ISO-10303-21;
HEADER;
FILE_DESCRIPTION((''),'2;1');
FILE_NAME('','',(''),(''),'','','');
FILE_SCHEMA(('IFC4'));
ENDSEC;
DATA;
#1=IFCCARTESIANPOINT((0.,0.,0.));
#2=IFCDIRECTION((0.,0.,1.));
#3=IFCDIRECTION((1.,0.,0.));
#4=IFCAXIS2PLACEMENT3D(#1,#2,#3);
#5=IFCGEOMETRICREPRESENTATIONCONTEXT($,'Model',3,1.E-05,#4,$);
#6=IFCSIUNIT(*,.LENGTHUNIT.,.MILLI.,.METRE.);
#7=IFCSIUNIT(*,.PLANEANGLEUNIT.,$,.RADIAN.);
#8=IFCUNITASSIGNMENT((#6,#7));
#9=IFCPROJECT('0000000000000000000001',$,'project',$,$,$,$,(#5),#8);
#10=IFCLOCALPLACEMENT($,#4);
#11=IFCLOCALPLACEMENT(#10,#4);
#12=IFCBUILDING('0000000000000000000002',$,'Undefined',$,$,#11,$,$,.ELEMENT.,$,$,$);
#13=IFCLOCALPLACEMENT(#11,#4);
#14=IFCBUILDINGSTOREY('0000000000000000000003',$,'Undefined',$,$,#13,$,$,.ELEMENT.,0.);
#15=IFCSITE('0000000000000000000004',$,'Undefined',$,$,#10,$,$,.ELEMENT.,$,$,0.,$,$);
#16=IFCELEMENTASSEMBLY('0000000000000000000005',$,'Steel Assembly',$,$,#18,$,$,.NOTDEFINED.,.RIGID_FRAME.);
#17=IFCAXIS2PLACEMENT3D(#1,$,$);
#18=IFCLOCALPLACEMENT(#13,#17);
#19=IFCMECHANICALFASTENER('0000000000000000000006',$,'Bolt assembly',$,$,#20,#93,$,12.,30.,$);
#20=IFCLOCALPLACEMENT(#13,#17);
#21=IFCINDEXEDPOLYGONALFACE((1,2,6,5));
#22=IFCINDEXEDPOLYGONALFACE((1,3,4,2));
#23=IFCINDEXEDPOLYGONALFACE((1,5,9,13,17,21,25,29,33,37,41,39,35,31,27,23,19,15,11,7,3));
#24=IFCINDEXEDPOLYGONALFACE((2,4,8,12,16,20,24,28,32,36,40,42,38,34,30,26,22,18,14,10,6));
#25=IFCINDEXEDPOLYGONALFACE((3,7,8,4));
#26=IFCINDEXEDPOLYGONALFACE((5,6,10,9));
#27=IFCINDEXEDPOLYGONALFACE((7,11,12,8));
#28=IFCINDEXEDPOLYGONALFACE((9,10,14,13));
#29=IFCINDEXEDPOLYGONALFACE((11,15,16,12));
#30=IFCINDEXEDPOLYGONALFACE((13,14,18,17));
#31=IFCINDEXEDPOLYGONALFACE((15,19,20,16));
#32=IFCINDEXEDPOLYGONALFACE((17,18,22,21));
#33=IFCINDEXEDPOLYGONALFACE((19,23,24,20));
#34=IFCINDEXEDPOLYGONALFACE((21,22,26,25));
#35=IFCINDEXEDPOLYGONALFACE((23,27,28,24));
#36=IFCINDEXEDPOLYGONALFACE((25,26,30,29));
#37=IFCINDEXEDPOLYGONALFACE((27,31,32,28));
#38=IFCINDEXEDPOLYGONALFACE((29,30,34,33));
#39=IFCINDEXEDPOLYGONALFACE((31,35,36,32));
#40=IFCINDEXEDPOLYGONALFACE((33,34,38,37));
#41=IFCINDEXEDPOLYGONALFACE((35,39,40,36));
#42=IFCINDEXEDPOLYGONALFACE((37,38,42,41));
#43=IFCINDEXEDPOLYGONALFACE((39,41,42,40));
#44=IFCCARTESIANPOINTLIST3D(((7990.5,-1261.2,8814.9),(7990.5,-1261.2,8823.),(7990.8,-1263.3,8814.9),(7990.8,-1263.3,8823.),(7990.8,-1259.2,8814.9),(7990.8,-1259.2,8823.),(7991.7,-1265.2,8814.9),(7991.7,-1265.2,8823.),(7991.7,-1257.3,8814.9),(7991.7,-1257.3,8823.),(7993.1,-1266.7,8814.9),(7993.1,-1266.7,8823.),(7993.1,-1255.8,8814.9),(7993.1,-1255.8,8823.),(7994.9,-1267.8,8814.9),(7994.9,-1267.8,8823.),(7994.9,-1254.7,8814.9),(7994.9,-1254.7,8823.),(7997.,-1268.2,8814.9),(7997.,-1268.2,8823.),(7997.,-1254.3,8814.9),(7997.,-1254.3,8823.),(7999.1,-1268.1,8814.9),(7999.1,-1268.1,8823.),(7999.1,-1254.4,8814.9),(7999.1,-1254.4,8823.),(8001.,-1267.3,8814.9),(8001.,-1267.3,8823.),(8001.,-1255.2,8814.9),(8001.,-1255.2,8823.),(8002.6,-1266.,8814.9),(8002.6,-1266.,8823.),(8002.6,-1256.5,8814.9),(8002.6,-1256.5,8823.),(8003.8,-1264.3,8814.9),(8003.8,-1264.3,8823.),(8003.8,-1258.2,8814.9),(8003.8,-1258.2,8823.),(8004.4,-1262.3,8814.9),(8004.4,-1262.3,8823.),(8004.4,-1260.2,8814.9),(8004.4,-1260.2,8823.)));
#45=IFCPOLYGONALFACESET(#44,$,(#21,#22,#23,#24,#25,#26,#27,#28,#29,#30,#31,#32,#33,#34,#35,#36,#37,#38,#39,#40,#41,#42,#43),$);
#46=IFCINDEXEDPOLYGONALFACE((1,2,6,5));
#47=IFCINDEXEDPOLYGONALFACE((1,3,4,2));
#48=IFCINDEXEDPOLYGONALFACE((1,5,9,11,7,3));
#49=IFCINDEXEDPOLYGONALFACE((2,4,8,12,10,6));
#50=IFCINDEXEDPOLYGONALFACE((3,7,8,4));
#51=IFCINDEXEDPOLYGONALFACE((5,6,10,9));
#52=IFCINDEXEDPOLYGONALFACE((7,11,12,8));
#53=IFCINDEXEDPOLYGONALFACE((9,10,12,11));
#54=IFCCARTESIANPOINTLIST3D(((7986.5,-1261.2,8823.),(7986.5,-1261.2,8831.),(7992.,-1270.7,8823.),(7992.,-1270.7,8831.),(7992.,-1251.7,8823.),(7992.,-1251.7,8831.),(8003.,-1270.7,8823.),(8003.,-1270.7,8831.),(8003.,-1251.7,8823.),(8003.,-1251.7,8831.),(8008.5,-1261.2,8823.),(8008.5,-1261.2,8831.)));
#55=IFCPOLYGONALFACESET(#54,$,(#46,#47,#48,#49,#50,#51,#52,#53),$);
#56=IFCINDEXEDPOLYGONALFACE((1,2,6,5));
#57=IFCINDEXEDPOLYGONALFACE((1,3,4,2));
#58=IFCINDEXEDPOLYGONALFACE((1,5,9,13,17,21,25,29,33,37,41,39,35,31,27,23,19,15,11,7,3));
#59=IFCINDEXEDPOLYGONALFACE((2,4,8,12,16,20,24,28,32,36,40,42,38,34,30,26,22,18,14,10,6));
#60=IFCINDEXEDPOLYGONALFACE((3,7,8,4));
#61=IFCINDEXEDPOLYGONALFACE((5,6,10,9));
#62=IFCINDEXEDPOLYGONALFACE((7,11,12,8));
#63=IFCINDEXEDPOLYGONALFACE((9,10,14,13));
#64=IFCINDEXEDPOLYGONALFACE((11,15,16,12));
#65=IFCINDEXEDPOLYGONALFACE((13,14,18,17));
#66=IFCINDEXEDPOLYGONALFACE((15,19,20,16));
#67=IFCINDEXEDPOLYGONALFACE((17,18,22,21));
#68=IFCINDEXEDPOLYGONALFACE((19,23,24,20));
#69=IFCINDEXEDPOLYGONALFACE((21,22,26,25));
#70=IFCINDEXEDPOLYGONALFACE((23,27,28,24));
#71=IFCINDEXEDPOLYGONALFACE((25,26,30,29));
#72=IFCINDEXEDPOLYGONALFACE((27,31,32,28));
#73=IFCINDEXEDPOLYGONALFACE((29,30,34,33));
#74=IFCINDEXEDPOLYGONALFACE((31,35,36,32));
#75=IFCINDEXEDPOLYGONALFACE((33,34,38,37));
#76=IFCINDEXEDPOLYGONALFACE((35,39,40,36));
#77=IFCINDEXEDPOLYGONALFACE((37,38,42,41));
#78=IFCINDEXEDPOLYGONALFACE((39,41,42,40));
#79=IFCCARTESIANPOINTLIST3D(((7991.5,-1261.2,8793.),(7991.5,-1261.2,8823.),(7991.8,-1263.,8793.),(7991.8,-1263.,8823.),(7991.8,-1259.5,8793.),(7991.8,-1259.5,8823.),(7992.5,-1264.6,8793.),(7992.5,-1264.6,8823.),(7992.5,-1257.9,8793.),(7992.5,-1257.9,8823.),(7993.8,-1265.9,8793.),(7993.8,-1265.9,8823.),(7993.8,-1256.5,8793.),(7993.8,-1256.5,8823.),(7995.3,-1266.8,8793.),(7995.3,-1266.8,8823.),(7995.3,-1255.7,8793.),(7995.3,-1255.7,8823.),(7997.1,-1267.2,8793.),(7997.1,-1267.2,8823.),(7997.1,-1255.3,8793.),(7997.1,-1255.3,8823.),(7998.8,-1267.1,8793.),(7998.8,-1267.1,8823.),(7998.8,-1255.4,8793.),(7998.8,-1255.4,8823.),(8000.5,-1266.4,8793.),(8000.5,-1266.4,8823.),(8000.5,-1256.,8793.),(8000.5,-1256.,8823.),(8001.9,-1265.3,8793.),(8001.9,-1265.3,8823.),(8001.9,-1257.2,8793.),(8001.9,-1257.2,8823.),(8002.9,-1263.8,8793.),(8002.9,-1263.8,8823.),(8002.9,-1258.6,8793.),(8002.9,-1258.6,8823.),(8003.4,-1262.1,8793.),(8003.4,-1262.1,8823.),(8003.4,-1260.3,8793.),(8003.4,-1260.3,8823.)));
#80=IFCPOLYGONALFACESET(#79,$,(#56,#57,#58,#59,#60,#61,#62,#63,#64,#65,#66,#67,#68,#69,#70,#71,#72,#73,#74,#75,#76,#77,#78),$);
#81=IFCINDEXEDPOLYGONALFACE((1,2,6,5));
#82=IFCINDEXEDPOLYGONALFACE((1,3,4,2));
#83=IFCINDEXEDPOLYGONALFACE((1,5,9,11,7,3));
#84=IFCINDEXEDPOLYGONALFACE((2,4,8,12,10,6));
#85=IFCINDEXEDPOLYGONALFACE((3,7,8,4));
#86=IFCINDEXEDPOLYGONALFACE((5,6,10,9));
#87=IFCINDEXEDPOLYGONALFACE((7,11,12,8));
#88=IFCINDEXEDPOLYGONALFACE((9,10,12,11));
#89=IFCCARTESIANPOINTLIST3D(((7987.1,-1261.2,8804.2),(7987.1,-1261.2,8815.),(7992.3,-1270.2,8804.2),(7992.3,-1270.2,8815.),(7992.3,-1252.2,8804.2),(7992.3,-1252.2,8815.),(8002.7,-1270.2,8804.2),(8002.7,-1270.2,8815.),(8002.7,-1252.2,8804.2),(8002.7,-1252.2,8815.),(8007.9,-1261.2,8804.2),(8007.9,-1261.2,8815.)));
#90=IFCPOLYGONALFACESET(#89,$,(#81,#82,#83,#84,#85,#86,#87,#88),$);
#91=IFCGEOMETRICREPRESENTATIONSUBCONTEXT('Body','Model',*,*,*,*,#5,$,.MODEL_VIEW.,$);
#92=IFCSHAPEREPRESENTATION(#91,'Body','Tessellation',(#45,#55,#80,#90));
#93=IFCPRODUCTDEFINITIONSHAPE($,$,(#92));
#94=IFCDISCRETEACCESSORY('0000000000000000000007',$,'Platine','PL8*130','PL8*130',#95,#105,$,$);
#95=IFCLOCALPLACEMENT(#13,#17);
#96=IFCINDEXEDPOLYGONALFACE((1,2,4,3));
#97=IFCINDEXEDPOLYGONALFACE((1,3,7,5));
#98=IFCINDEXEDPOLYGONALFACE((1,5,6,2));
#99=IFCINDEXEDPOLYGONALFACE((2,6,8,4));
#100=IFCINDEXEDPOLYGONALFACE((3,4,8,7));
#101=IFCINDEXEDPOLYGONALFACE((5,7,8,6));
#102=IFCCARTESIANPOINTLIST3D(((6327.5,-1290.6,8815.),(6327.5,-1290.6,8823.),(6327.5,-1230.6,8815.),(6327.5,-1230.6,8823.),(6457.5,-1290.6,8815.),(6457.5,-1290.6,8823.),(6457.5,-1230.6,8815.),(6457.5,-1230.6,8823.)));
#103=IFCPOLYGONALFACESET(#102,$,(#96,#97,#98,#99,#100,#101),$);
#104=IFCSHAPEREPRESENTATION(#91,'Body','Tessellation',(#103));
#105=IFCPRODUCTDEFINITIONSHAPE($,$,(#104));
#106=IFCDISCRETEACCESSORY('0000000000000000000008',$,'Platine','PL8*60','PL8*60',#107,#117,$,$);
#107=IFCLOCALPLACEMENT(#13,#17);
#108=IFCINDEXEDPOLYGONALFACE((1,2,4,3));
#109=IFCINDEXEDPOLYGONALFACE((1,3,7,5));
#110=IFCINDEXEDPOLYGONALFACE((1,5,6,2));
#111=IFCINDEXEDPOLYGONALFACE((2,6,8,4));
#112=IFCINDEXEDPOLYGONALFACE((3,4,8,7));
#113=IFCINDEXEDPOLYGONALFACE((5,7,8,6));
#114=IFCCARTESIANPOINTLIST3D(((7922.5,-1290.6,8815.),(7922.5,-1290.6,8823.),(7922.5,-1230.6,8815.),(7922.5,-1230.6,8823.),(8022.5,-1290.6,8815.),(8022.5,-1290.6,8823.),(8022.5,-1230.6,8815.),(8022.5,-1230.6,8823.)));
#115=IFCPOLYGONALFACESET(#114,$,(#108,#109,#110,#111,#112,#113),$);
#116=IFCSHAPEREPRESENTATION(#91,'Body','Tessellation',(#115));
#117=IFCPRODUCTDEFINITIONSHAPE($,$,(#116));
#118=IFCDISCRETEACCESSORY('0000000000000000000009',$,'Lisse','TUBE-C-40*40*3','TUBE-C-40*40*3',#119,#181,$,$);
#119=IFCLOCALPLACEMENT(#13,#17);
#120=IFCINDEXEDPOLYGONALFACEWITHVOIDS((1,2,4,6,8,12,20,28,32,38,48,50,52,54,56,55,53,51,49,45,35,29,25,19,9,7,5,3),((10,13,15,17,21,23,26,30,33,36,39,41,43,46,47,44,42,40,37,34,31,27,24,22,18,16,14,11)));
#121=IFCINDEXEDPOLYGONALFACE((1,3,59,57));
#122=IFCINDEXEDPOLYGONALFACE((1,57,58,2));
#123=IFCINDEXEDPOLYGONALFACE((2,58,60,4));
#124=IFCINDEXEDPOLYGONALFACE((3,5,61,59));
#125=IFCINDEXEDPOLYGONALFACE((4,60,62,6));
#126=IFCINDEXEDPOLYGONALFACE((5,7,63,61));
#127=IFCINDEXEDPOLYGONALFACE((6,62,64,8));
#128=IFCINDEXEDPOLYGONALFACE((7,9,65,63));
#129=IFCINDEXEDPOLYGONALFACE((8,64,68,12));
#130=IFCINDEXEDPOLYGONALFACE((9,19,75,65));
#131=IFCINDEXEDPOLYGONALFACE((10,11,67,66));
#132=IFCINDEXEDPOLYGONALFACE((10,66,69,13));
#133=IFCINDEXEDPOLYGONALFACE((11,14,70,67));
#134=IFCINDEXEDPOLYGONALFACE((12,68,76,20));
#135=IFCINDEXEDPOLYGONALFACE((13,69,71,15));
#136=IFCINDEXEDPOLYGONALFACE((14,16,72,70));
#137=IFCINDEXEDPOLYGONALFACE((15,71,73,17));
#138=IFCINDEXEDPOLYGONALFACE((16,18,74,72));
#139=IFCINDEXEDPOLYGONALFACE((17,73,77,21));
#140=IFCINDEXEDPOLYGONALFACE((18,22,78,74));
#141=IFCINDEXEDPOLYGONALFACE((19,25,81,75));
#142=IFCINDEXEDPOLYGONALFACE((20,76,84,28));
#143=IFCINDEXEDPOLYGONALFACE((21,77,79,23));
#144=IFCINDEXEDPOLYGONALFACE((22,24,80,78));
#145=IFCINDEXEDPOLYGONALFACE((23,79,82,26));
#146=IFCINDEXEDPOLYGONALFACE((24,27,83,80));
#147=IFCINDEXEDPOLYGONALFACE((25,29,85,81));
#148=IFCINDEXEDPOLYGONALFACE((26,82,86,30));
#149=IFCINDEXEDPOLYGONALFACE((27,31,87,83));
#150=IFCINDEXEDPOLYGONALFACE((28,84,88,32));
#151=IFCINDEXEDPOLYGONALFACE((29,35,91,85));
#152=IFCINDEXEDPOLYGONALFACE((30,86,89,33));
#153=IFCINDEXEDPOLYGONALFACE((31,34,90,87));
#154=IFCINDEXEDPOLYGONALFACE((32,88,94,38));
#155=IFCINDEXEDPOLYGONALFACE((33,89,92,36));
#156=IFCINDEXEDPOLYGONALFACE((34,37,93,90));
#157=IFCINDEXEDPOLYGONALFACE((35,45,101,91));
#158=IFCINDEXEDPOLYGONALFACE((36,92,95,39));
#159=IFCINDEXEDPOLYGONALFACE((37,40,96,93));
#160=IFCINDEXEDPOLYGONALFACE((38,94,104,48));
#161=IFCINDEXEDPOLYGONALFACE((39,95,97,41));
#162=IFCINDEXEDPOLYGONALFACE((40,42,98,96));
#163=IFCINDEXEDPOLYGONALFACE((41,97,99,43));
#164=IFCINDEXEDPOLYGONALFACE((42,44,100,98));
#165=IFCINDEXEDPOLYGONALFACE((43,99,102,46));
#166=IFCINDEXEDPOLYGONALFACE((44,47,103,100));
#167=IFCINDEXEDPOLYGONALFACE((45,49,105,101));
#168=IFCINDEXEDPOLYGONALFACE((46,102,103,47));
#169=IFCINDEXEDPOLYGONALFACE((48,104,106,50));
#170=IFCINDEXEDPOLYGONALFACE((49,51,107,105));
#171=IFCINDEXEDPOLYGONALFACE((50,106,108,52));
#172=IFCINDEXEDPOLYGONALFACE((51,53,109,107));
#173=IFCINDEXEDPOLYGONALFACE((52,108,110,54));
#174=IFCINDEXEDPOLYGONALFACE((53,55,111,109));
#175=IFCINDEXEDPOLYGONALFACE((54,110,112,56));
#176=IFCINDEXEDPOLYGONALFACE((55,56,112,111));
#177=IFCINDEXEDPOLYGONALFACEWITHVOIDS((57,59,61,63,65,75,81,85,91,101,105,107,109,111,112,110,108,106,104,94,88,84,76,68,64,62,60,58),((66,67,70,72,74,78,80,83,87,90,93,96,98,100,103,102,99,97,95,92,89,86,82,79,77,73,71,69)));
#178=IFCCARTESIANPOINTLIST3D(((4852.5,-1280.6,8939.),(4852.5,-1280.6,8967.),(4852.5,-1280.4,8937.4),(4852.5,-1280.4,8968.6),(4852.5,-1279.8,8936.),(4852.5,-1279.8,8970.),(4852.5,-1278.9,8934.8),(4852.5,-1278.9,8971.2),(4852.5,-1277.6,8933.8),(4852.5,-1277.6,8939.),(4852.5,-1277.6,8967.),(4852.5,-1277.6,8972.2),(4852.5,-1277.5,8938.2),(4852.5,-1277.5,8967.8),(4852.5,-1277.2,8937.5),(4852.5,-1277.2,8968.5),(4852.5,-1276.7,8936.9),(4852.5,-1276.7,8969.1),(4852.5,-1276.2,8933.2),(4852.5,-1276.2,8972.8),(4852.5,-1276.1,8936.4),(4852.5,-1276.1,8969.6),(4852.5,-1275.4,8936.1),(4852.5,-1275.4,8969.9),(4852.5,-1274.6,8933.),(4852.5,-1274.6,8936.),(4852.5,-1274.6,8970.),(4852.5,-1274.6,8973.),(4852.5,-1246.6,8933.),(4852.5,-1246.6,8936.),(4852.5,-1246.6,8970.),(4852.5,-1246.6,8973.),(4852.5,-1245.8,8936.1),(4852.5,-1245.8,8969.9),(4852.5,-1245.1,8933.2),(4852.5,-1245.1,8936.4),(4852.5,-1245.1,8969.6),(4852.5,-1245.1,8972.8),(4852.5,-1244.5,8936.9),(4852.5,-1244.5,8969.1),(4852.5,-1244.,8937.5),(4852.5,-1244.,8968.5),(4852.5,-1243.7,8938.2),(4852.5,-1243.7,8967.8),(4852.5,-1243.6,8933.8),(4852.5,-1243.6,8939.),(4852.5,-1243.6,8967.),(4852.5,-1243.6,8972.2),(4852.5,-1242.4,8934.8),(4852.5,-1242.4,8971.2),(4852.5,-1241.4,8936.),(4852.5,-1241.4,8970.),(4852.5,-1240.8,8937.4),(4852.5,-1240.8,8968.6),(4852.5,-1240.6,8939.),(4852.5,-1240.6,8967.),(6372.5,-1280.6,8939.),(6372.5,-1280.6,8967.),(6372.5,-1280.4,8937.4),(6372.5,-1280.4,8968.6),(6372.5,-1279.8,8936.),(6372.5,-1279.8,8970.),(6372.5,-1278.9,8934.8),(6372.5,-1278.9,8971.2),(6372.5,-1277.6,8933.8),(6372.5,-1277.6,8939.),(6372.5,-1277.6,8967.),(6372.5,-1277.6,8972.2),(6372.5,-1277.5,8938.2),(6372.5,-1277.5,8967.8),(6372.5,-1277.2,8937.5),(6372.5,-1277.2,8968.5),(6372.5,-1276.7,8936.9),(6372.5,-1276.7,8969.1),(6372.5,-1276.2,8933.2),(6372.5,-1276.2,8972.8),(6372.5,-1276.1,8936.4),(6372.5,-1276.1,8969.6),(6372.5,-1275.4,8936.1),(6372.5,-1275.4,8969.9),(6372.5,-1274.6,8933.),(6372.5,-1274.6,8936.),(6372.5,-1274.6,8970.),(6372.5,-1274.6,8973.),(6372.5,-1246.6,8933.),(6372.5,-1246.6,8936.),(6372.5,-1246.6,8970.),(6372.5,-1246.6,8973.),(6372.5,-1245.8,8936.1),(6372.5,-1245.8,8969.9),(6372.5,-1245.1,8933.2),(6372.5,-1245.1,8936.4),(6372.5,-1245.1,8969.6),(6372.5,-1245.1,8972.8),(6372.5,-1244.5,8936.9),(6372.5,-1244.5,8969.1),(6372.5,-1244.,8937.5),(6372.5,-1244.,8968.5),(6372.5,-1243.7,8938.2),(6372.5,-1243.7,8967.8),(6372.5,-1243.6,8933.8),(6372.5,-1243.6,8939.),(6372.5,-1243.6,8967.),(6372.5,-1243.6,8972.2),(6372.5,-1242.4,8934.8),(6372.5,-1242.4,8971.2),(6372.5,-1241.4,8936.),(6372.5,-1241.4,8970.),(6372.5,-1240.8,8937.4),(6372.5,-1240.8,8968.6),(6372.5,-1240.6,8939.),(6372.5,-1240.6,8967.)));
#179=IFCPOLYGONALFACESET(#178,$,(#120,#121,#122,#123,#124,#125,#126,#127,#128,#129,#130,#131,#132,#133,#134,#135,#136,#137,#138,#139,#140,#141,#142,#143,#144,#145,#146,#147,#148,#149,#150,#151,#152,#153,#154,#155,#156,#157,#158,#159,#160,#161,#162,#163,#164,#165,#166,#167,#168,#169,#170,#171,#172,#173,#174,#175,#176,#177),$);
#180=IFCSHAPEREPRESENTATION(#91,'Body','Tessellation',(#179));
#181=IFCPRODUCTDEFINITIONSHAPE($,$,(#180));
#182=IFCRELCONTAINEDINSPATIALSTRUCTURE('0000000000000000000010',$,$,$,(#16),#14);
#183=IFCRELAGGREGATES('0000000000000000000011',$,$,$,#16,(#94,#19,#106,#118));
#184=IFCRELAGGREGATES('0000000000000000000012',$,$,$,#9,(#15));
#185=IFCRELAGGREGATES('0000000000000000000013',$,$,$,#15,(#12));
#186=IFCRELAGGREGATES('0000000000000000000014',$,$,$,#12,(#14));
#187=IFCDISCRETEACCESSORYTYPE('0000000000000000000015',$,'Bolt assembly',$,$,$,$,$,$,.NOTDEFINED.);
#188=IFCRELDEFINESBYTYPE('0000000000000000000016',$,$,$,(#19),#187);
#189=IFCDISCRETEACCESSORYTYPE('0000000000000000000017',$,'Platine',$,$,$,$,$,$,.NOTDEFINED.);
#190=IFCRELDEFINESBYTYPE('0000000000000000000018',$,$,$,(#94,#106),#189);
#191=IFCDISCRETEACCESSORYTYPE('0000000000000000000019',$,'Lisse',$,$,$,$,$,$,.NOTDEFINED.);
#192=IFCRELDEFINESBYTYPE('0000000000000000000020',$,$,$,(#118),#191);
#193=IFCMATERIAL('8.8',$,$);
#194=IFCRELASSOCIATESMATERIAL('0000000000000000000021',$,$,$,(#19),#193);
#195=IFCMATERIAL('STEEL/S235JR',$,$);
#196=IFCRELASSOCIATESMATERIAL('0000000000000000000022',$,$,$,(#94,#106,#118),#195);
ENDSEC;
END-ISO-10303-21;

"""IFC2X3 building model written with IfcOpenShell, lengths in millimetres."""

from ifc_helpers import new_model, si_unit, frame, origin_with_axes, origin_2d_with_axis, place, context, subcontext, project, spatial, polyline, hollow_rectangle, circle, outline, extrude, source, transform, mapped, material, type_object, element, aggregate, save


model = new_model("IFC2X3")

# Units and contexts
model_context = context("Model", 3, precision=1e-05, world=origin_with_axes())
body_context = subcontext(model_context, "Body", "Model", "MODEL_VIEW")
ifc_project = project(units=[si_unit("LENGTHUNIT", "METRE", prefix="MILLI"), si_unit("PLANEANGLEUNIT", "RADIAN")], contexts=[model_context])

# Site, building, storey
site_placement = place(None, origin_with_axes())
site = spatial("IfcSite", under=ifc_project, at=site_placement, Name="Undefined", CompositionType="ELEMENT", RefElevation=0.0)
building_placement = place(site_placement, origin_with_axes())
building = spatial("IfcBuilding", under=site, at=building_placement, Name="Undefined", CompositionType="ELEMENT")
storey_placement = place(building_placement, origin_with_axes())
storey = spatial("IfcBuildingStorey", under=building, at=storey_placement, Name="Undefined", CompositionType="ELEMENT", Elevation=0.0)

# Element assembly
assembly_1_placement = place(storey_placement, origin_with_axes())
assembly_1 = element("IfcElementAssembly", 1, at=assembly_1_placement, inside=storey, Name="Steel Assembly", AssemblyPlace="NOTDEFINED", PredefinedType="RIGID_FRAME")
ifc_material_1 = material(Name="STEEL/S235JR")

# Mechanical fastener
ifc_material_2 = material(Name="8.8")
discrete_accessory_type_1 = type_object("IfcDiscreteAccessoryType", Name="Bolt assembly")
shared_shape_1 = source(origin_with_axes(), body_context, "Body", "SweptSolid", [
    extrude(circle(Radius=7.0, at=origin_2d_with_axis()), frame((0.0, 0.0, 0.0), z_axis=(0.0, 1.0, 0.0), x_axis=(1.0, 0.0, 0.0)), (0.0, 0.0, 1.0), 8.1),
    extrude(outline(polyline([(11.0, 0.0), (5.5, 9.5), (-5.5, 9.5), (-11.0, 0.0), (-5.5, -9.5), (5.5, -9.5), (11.0, 0.0)])), frame((0.0, -8.0, 0.0), z_axis=(0.0, 1.0, 0.0), x_axis=(1.0, 0.0, 0.0)), (0.0, 0.0, 1.0), 8.0),
    extrude(circle(Radius=6.0, at=origin_2d_with_axis()), frame((0.0, 0.0, 0.0), z_axis=(0.0, 1.0, 0.0), x_axis=(1.0, 0.0, 0.0)), (0.0, 0.0, 1.0), 30.0),
    extrude(outline(polyline([(10.4, 0.0), (5.2, 9.0), (-5.2, 9.0), (-10.4, 0.0), (-5.2, -9.0), (5.2, -9.0), (10.4, 0.0)])), frame((0.0, 8.0, 0.0), z_axis=(0.0, 1.0, 0.0), x_axis=(1.0, 0.0, 0.0)), (0.0, 0.0, 1.0), 10.8),
])
mechanical_fastener_1_placement = place(assembly_1_placement, frame((7997.5, -1261.2, 8823.0), z_axis=(0.0, -1.0, 0.0), x_axis=(-1.0, 0.0, 0.0)))
mechanical_fastener_1 = element("IfcMechanicalFastener", 2, at=mechanical_fastener_1_placement, type_object=discrete_accessory_type_1, material=ifc_material_2, Name="Bolt assembly", NominalDiameter=12.0, NominalLength=30.0, context=body_context, shape_type="MappedRepresentation", body=[
    mapped(shared_shape_1, transform((0.0, 0.0, 0.0))),
])

# Discrete accessories
discrete_accessory_type_2 = type_object("IfcDiscreteAccessoryType", Name="Platine")
discrete_accessory_1_placement = place(assembly_1_placement, frame((6392.5, -1290.6, 8819.0), z_axis=(0.0, 0.0, 1.0), x_axis=(0.0, 1.0, 0.0)))
discrete_accessory_1 = element("IfcDiscreteAccessory", 3, at=discrete_accessory_1_placement, type_object=discrete_accessory_type_2, material=ifc_material_1, Name="Platine", Description="PL8*130", ObjectType="PL8*130", context=body_context, shape_type="SweptSolid", body=[
    extrude(outline(polyline([(60.0, 65.0), (60.0, -65.0), (0.0, -65.0), (0.0, 65.0), (60.0, 65.0)])), frame((0.0, 0.0, -4.0), z_axis=(0.0, 0.0, 1.0), x_axis=(1.0, 0.0, 0.0)), (0.0, 0.0, 1.0), 8.0),
])
discrete_accessory_2_placement = place(assembly_1_placement, frame((7922.5, -1230.6, 8819.0), z_axis=(0.0, 0.0, -1.0), x_axis=(1.0, 0.0, 0.0)))
discrete_accessory_2 = element("IfcDiscreteAccessory", 4, at=discrete_accessory_2_placement, type_object=discrete_accessory_type_2, material=ifc_material_1, Name="Platine", Description="PL8*60", ObjectType="PL8*60", context=body_context, shape_type="SweptSolid", body=[
    extrude(outline(polyline([(0.0, 0.0), (100.0, 0.0), (100.0, 60.0), (0.0, 60.0), (0.0, 0.0)])), frame((0.0, 0.0, -4.0), z_axis=(0.0, 0.0, 1.0), x_axis=(1.0, 0.0, 0.0)), (0.0, 0.0, 1.0), 8.0),
])

# Discrete accessory
discrete_accessory_type_3 = type_object("IfcDiscreteAccessoryType", Name="Lisse")
discrete_accessory_3_placement = place(assembly_1_placement, frame((6372.5, -1260.6, 8953.0), z_axis=(0.0, 1.0, 0.0), x_axis=(-1.0, 0.0, 0.0)))
discrete_accessory_3 = element("IfcDiscreteAccessory", 5, at=discrete_accessory_3_placement, type_object=discrete_accessory_type_3, material=ifc_material_1, Name="Lisse", Description="TUBE-C-40*40*3", ObjectType="TUBE-C-40*40*3", context=body_context, shape_type="SweptSolid", body=[
    extrude(hollow_rectangle(XDim=40.0, YDim=40.0, WallThickness=3.0, InnerFilletRadius=3.0, OuterFilletRadius=6.0, at=origin_2d_with_axis()), frame((1520.0, 0.0, 0.0), z_axis=(-1.0, 0.0, 0.0), x_axis=(0.0, -1.0, 0.0)), (0.0, 0.0, 1.0), 1520.0),
])
aggregate(assembly_1, [discrete_accessory_1, mechanical_fastener_1, discrete_accessory_2, discrete_accessory_3])

save(model, "model.ifc")
